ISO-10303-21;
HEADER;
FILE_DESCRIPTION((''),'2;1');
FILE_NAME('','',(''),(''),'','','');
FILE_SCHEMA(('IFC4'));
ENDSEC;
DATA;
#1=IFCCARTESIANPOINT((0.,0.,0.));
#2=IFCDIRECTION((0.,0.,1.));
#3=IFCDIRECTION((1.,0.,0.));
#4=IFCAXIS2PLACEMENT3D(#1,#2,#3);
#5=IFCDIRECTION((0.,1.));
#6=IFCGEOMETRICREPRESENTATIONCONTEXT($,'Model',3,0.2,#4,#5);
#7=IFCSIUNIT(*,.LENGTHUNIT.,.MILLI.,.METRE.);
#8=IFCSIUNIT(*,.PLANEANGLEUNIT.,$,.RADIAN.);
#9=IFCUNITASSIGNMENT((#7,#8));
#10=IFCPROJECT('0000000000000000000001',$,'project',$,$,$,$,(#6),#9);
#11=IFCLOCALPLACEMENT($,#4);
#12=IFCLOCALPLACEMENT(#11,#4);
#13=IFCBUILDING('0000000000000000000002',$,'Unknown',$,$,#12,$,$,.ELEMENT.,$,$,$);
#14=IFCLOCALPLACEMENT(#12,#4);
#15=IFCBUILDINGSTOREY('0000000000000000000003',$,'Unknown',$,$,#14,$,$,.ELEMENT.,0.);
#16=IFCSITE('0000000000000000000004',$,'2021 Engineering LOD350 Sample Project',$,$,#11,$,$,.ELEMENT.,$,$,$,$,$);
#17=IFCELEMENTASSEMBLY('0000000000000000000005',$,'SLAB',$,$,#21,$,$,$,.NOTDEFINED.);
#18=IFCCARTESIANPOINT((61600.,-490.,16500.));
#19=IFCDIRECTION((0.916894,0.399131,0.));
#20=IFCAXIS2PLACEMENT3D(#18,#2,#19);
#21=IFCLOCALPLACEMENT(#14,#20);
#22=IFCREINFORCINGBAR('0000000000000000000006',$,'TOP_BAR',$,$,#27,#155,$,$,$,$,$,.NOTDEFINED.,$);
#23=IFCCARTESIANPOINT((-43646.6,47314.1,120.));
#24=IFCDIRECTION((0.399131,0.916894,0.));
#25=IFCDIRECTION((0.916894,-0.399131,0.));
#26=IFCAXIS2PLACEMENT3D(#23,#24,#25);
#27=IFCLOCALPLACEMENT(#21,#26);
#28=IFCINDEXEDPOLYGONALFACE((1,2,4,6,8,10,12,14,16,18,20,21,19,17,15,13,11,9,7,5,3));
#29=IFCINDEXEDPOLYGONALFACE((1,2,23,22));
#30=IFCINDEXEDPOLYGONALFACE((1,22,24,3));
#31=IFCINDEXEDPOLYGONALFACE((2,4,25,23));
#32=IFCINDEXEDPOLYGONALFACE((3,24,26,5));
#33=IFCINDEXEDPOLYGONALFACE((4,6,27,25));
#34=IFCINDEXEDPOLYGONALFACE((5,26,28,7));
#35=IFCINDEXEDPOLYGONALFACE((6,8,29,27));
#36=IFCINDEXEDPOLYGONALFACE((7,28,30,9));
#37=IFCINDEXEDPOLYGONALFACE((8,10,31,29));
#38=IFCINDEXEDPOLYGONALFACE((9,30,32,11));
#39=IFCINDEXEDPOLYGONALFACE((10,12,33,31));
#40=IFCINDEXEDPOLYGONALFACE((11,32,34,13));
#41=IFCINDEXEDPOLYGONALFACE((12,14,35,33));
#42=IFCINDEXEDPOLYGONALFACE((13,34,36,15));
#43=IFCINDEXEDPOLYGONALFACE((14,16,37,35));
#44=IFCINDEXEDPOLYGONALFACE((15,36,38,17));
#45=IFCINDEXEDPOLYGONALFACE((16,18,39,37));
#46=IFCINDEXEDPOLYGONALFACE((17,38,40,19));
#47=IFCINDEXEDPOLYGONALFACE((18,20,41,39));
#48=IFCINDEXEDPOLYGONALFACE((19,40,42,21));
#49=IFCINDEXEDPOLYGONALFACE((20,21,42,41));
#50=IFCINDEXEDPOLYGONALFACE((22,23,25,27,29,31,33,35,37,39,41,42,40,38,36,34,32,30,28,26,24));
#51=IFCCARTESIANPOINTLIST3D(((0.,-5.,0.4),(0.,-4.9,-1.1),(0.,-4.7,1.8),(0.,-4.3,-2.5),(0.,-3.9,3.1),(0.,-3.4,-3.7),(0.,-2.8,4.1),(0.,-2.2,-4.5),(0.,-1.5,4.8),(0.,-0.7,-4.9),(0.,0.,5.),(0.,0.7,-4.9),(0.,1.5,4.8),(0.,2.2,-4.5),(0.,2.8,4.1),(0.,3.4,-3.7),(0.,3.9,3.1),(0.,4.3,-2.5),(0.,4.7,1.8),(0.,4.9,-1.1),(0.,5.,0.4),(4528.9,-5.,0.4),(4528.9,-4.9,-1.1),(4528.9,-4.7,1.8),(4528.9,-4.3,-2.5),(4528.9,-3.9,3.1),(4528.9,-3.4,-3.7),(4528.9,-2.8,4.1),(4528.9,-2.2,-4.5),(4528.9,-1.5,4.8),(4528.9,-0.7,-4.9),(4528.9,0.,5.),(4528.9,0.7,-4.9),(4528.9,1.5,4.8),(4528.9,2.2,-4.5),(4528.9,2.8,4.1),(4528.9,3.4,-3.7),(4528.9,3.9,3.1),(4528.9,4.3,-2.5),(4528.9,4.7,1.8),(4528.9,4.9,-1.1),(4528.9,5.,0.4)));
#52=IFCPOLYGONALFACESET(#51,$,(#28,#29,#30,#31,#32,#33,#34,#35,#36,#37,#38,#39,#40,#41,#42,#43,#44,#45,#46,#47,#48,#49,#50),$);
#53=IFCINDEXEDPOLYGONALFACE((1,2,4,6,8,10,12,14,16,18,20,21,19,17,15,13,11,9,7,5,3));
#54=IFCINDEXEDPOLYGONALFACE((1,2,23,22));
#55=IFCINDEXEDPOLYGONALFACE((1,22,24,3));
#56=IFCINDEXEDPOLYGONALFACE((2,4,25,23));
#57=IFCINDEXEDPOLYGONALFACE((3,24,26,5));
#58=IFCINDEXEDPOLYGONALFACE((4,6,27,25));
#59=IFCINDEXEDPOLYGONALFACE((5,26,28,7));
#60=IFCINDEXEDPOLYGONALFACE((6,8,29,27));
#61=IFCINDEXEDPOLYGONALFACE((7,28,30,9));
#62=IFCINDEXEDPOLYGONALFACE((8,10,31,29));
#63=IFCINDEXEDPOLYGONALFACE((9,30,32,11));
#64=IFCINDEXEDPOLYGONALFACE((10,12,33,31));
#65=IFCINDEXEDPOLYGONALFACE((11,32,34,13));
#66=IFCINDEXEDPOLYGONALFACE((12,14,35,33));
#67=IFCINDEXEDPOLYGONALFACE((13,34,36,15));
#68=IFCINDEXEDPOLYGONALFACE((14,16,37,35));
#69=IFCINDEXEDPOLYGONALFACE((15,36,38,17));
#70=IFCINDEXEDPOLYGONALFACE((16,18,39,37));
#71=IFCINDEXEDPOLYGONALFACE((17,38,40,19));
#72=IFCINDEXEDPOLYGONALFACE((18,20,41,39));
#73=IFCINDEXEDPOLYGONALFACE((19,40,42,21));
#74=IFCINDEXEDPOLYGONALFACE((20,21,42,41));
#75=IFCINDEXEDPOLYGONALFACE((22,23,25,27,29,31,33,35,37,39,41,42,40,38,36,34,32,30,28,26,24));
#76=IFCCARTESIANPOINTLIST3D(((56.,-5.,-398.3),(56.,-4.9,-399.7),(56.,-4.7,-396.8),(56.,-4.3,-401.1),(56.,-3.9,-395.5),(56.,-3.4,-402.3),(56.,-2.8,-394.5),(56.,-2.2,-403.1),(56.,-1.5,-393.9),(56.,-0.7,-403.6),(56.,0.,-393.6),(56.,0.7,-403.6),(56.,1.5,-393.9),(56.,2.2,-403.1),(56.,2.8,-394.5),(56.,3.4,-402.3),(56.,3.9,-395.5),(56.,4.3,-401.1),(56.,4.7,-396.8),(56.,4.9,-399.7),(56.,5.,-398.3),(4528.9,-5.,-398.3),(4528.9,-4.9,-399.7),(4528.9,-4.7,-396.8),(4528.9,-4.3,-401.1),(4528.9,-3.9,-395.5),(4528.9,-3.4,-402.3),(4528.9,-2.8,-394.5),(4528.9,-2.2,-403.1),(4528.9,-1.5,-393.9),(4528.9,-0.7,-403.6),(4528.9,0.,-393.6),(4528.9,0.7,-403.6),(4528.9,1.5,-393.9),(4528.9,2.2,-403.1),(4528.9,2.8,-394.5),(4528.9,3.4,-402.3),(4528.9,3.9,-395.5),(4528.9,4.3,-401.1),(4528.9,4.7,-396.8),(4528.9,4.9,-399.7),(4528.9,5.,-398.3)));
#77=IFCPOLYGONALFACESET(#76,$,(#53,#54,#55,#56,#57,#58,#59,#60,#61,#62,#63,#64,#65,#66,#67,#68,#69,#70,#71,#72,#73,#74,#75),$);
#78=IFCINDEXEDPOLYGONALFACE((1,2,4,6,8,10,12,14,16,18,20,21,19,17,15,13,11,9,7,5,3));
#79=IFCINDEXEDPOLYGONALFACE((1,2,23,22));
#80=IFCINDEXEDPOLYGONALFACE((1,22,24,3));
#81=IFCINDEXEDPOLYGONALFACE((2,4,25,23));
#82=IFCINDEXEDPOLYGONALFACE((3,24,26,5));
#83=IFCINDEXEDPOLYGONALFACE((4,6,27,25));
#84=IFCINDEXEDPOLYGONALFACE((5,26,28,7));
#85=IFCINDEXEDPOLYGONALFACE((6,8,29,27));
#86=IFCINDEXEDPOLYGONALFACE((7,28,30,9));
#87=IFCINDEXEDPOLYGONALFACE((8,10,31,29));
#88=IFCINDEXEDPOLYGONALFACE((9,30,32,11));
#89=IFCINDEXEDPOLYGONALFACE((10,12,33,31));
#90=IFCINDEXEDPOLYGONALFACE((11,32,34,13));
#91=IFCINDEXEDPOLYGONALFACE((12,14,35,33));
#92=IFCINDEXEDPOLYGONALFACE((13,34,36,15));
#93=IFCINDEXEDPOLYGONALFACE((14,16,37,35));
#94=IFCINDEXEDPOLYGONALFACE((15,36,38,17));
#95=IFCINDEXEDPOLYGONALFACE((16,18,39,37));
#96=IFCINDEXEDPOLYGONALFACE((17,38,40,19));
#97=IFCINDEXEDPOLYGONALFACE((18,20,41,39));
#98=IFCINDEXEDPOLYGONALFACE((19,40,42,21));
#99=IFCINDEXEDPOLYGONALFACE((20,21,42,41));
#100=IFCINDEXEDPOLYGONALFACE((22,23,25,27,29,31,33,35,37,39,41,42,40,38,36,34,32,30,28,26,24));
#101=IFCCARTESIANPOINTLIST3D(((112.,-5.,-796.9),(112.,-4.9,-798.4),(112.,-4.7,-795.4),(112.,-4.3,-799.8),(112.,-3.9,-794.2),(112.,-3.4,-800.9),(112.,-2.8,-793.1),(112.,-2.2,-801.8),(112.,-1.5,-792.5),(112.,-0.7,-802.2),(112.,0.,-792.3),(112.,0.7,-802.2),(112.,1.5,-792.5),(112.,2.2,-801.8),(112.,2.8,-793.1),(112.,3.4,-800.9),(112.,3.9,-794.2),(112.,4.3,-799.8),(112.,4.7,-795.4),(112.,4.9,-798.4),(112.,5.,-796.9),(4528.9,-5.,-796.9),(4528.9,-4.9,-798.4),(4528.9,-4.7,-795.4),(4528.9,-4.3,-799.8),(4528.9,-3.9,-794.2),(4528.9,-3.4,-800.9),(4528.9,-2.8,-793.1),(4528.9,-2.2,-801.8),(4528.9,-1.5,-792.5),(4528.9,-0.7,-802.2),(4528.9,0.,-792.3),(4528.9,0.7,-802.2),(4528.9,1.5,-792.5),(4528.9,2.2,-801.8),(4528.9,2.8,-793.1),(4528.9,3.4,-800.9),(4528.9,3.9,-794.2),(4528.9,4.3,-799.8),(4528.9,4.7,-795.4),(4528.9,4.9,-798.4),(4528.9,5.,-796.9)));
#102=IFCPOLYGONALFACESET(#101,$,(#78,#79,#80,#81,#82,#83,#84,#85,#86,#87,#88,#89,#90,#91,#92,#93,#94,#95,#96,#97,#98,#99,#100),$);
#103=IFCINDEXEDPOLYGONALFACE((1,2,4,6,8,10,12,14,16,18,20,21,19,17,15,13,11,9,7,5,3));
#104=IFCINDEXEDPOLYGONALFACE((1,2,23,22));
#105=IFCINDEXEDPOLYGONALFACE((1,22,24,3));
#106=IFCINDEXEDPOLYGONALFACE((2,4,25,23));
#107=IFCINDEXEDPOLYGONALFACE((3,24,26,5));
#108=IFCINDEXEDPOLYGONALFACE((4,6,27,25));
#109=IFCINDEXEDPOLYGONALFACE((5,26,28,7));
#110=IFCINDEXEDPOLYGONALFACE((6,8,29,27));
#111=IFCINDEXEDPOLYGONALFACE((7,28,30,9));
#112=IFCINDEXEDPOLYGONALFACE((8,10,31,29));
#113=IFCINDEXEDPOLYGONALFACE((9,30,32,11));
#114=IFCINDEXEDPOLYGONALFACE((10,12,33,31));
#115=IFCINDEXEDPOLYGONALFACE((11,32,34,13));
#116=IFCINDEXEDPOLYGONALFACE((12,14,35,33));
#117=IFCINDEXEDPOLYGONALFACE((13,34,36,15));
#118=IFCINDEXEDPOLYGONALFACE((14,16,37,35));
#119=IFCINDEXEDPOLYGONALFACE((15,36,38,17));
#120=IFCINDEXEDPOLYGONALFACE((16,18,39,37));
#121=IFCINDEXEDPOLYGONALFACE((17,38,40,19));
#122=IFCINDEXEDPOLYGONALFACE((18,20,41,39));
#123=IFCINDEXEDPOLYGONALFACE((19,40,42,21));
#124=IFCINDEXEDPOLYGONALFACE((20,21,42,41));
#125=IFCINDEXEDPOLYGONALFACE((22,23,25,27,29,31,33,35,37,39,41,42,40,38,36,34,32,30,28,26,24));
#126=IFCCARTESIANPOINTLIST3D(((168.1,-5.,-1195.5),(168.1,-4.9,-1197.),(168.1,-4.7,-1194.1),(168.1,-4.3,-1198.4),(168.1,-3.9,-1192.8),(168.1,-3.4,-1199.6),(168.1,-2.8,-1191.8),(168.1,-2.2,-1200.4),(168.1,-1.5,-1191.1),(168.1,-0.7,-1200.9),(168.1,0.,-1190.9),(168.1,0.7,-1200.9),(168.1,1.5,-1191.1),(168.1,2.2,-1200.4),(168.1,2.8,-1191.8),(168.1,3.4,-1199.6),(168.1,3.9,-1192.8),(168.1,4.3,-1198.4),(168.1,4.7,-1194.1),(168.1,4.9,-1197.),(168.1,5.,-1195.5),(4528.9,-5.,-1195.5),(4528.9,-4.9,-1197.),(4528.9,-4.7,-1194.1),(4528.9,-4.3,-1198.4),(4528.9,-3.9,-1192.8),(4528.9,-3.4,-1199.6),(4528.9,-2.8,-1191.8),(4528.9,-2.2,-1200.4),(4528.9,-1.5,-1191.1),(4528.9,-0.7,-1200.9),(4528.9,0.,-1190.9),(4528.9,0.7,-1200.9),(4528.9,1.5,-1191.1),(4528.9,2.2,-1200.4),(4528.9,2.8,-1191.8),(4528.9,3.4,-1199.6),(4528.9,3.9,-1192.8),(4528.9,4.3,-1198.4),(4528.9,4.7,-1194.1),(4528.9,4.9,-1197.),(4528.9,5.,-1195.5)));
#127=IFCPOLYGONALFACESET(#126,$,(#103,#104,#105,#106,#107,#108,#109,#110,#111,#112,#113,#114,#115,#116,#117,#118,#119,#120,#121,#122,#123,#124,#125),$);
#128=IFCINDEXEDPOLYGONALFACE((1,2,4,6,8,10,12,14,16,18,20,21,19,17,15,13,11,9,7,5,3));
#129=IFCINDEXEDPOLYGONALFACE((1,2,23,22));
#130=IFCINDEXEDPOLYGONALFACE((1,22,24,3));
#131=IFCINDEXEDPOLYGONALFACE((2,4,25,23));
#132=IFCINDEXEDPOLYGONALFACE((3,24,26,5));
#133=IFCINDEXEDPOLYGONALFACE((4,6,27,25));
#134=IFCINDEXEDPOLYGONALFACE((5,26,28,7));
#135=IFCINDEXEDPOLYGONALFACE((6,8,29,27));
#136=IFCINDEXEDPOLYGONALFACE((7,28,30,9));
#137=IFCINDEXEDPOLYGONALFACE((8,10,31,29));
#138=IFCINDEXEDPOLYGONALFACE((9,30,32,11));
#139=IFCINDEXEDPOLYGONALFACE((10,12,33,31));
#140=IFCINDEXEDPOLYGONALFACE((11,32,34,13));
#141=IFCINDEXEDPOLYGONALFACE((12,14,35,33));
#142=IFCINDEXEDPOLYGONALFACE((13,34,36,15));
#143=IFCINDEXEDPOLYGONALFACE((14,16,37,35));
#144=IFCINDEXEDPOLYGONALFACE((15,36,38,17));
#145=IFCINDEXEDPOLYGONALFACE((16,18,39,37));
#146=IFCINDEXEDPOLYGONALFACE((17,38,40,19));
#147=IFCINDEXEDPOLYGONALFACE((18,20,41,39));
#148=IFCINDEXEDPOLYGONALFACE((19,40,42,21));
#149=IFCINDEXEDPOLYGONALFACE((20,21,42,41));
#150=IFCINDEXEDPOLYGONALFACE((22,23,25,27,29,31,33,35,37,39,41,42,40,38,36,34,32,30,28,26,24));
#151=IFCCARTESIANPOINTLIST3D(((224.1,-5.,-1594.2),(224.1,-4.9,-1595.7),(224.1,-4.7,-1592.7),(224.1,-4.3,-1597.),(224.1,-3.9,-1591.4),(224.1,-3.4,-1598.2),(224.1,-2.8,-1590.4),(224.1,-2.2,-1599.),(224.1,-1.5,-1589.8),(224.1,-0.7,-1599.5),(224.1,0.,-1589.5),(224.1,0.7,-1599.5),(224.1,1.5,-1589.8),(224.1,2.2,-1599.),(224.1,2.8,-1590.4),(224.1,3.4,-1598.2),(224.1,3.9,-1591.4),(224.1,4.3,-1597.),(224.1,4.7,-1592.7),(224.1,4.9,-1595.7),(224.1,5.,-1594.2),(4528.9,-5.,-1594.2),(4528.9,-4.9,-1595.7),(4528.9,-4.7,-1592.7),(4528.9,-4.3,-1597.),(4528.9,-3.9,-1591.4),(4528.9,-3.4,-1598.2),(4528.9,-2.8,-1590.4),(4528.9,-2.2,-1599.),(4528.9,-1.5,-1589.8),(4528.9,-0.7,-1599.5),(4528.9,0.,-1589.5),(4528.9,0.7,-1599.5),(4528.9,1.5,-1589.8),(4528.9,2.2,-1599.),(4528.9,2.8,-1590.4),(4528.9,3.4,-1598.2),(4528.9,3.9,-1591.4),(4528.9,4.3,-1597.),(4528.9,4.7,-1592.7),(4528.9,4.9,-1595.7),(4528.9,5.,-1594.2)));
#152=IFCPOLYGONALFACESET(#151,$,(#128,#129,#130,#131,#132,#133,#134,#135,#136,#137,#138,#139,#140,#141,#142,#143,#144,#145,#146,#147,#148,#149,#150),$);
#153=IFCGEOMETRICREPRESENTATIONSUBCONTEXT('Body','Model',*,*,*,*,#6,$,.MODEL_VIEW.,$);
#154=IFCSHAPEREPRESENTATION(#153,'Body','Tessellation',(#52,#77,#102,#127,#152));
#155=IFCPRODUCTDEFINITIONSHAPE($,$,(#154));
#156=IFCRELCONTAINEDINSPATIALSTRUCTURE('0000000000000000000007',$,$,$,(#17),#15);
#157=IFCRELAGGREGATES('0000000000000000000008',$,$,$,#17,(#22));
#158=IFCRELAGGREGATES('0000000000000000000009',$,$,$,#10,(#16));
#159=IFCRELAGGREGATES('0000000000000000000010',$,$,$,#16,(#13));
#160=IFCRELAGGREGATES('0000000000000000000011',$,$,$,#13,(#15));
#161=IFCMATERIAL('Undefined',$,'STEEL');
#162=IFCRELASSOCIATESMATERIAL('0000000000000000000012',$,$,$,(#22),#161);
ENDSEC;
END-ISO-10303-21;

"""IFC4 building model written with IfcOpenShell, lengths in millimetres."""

from ifc_helpers import new_model, entity, si_unit, direction, frame, origin_with_axes, place, context, subcontext, project, spatial, material, element, aggregate, save


model = new_model("IFC4")

# Units and contexts
model_context = context("Model", 3, precision=0.2, world=origin_with_axes(), true_north=direction((0.0, 1.0)))
body_context = subcontext(model_context, "Body", "Model", "MODEL_VIEW")
ifc_project = project(units=[si_unit("LENGTHUNIT", "METRE", prefix="MILLI"), si_unit("PLANEANGLEUNIT", "RADIAN")], contexts=[model_context])

# Site, building, storey
site_placement = place(None, origin_with_axes())
site = spatial("IfcSite", under=ifc_project, at=site_placement, Name="2021 Engineering LOD350 Sample Project", CompositionType="ELEMENT")
building_placement = place(site_placement, origin_with_axes())
building = spatial("IfcBuilding", under=site, at=building_placement, Name="Unknown", CompositionType="ELEMENT")
storey_placement = place(building_placement, origin_with_axes())
storey = spatial("IfcBuildingStorey", under=building, at=storey_placement, Name="Unknown", CompositionType="ELEMENT", Elevation=0.0)

# Element assembly
assembly_1_placement = place(storey_placement, frame((61600.0, -490.0, 16500.0), z_axis=(0.0, 0.0, 1.0), x_axis=(0.916894, 0.399131, 0.0)))
assembly_1 = element("IfcElementAssembly", 1, at=assembly_1_placement, inside=storey, Name="SLAB", PredefinedType="NOTDEFINED")
ifc_material_1 = material(Name="Undefined", Category="STEEL")

# Reinforcing bar
reinforcing_bar_1_placement = place(assembly_1_placement, frame((-43646.6, 47314.1, 120.0), z_axis=(0.399131, 0.916894, 0.0), x_axis=(0.916894, -0.399131, 0.0)))
reinforcing_bar_1 = element("IfcReinforcingBar", 2, at=reinforcing_bar_1_placement, material=ifc_material_1, Name="TOP_BAR", PredefinedType="NOTDEFINED", context=body_context, shape_type="AdvancedSweptSolid", body=[
    entity("IfcSweptDiskSolid", entity("IfcIndexedPolyCurve", entity("IfcCartesianPointList3D", [[0.0, 0.0, 0.0], [4528.9, 0.0, 0.0]]), [entity("IfcLineIndex", [1, 2])]), 5.0),
    entity("IfcSweptDiskSolid", entity("IfcIndexedPolyCurve", entity("IfcCartesianPointList3D", [[56.0, 0.0, -398.6], [4528.9, 0.0, -398.6]]), [entity("IfcLineIndex", [1, 2])]), 5.0),
    entity("IfcSweptDiskSolid", entity("IfcIndexedPolyCurve", entity("IfcCartesianPointList3D", [[112.0, 0.0, -797.3], [4528.9, 0.0, -797.3]]), [entity("IfcLineIndex", [1, 2])]), 5.0),
    entity("IfcSweptDiskSolid", entity("IfcIndexedPolyCurve", entity("IfcCartesianPointList3D", [[168.1, 0.0, -1195.9], [4528.9, 0.0, -1195.9]]), [entity("IfcLineIndex", [1, 2])]), 5.0),
    entity("IfcSweptDiskSolid", entity("IfcIndexedPolyCurve", entity("IfcCartesianPointList3D", [[224.1, 0.0, -1594.5], [4528.9, 0.0, -1594.5]]), [entity("IfcLineIndex", [1, 2])]), 5.0),
])
aggregate(assembly_1, [reinforcing_bar_1])

save(model, "model.ifc")
